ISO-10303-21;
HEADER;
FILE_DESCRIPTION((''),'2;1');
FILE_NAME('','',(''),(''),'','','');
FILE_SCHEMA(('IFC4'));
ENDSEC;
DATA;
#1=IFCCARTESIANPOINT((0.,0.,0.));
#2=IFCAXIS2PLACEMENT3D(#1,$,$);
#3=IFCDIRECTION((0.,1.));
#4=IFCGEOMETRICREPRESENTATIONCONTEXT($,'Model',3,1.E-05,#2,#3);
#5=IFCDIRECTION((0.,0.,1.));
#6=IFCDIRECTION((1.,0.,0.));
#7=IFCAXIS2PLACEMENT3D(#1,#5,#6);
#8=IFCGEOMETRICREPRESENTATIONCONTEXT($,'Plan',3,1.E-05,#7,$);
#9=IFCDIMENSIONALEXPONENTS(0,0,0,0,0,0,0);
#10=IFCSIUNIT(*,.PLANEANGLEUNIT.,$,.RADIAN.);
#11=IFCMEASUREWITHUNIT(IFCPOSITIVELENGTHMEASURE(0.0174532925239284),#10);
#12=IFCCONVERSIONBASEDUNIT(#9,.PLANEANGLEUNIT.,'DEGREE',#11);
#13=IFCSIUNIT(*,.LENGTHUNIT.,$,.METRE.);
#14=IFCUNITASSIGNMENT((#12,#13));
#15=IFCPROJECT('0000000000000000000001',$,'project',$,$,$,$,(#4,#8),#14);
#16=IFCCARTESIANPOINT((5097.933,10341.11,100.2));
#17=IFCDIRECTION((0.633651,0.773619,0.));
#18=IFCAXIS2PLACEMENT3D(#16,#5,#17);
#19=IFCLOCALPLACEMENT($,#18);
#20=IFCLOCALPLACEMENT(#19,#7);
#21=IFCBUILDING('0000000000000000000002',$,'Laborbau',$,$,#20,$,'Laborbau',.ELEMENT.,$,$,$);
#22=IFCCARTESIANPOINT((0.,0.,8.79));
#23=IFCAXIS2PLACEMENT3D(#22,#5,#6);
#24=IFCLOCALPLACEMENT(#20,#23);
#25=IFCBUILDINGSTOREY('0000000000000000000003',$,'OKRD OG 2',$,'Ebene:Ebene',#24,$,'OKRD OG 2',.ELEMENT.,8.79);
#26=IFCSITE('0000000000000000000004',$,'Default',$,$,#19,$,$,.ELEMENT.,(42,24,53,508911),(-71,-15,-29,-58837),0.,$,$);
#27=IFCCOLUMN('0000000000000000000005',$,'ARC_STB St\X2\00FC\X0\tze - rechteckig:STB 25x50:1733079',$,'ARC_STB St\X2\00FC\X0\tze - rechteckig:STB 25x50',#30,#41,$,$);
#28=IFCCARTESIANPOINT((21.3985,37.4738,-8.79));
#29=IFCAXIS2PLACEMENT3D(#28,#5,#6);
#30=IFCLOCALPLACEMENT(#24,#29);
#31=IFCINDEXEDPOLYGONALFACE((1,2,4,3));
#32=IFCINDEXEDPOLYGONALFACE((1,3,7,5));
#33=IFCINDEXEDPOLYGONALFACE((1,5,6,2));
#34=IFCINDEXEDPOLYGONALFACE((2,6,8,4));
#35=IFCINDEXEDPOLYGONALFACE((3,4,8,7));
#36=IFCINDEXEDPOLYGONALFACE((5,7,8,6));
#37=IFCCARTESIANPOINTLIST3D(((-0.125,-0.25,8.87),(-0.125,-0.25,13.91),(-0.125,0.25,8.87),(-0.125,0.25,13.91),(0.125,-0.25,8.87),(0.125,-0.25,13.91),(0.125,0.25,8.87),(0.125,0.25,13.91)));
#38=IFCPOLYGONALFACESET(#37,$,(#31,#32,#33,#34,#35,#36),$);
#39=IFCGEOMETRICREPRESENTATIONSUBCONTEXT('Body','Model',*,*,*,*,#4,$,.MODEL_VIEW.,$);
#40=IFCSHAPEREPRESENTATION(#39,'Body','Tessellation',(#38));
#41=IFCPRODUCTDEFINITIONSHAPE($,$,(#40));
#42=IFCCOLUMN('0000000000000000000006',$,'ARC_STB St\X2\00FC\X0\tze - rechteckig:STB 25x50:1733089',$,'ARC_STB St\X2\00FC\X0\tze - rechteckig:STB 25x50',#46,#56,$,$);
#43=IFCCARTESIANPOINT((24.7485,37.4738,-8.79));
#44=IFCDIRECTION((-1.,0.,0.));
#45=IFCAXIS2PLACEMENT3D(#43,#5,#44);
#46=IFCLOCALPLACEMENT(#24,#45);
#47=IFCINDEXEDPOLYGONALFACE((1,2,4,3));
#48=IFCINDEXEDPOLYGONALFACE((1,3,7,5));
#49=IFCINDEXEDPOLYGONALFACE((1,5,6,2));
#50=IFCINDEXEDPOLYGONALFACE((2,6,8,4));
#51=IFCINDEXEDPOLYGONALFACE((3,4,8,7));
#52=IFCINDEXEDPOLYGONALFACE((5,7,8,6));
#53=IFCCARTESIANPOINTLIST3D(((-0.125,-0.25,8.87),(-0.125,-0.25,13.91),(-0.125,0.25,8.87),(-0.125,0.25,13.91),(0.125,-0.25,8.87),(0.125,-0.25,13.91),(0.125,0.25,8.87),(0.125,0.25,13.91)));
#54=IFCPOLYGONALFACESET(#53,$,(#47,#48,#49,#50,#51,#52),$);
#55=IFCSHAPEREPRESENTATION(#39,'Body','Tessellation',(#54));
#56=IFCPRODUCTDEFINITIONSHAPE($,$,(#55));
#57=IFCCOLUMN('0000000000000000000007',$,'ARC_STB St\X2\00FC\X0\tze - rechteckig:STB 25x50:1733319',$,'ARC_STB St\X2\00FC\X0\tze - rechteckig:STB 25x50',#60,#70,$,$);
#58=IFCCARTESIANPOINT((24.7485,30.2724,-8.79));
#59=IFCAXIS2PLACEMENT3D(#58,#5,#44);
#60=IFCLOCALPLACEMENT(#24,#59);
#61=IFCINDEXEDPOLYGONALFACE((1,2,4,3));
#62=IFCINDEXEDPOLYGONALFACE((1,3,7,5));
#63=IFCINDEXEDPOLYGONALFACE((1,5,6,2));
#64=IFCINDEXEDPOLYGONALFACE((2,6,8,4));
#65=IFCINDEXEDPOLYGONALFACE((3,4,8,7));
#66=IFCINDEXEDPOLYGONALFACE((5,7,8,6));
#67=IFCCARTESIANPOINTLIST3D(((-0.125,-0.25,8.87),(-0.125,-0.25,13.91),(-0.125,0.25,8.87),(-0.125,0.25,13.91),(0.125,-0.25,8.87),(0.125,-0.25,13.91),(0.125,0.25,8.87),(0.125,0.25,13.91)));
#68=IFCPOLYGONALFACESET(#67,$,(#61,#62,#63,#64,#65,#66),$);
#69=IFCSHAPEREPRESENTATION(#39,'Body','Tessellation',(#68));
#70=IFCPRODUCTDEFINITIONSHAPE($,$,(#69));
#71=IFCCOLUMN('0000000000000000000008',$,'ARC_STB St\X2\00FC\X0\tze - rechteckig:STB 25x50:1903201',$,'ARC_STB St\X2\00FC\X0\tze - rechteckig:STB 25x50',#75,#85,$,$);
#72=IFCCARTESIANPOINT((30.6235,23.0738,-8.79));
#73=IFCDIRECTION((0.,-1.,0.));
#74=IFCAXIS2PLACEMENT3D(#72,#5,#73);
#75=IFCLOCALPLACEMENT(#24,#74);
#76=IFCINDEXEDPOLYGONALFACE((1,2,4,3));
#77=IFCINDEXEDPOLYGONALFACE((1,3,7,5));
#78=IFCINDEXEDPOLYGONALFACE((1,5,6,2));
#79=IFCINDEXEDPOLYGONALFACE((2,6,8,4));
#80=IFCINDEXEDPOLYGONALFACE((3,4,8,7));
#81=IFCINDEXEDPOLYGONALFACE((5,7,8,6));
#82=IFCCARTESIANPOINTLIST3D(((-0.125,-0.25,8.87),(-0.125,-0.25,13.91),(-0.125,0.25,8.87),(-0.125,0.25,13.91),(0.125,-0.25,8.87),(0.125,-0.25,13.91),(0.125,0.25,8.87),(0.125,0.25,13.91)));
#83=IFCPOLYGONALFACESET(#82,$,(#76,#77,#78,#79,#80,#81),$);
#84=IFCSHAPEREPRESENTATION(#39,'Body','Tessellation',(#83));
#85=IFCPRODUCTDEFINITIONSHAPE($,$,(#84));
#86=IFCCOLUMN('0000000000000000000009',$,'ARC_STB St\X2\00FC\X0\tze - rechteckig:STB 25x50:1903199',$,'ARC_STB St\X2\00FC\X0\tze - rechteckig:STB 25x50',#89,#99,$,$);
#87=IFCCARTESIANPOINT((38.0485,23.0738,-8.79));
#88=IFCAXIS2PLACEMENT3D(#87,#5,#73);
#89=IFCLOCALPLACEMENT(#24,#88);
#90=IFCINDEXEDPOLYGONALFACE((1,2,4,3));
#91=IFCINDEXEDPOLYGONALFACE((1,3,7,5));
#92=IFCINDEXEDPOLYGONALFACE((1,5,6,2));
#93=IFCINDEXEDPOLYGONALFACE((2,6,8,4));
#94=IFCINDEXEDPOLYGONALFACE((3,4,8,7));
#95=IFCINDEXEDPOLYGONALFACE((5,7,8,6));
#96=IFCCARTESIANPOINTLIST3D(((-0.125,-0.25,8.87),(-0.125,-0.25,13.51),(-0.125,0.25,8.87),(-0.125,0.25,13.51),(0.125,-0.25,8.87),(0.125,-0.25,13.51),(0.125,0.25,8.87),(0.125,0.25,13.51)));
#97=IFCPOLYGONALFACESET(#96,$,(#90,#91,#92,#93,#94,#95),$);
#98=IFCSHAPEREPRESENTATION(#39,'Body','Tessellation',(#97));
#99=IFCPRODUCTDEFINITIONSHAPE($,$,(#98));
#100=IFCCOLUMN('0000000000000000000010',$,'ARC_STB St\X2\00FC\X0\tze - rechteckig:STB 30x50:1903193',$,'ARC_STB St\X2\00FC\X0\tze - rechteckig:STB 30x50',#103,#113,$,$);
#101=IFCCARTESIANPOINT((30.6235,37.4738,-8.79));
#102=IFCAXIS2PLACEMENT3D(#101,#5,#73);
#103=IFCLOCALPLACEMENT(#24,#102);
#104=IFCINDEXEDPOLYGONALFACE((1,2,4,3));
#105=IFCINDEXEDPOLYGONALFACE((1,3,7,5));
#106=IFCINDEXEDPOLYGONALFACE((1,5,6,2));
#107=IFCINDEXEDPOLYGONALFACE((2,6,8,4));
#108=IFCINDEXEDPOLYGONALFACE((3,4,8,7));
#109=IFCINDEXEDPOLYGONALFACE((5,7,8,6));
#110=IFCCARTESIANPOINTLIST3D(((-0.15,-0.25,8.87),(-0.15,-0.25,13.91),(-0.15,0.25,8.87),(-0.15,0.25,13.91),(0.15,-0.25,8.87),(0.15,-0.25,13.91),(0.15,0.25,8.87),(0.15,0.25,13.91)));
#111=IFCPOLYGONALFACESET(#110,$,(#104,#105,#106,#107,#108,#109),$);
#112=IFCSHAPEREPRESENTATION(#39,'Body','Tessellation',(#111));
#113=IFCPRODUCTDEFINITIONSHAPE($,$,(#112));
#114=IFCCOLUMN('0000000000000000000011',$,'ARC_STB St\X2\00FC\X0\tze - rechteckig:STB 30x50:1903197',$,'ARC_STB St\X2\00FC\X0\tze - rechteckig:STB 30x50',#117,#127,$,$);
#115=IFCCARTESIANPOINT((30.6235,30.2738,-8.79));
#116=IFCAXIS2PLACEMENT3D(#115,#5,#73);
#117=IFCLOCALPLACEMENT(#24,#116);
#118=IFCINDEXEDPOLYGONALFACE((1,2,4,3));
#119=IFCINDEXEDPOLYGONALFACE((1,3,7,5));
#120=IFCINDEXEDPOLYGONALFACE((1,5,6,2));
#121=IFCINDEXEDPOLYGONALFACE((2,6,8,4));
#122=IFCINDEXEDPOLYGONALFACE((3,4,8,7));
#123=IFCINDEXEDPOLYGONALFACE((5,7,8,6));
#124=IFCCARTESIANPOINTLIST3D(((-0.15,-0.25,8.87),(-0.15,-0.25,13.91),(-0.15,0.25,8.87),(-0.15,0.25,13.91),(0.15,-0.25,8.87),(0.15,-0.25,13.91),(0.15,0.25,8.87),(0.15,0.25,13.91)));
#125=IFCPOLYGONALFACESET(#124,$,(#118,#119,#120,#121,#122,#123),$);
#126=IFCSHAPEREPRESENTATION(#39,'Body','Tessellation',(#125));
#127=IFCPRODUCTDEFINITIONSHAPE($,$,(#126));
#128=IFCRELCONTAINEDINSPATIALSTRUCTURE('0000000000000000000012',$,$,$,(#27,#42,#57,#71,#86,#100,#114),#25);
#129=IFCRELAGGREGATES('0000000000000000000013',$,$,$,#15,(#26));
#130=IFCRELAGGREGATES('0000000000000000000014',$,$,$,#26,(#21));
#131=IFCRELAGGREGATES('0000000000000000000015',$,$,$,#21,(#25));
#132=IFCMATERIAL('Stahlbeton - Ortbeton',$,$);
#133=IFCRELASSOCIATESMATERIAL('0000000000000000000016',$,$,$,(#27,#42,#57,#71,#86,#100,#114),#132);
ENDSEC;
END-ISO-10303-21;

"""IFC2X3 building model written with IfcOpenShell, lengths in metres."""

from ifc_helpers import new_model, entity, si_unit, converted_unit, direction, frame, origin, origin_with_axes, origin_2d_with_axis, place, context, subcontext, project, spatial, rectangle, extrude, source, transform, mapped, material, element, save


model = new_model("IFC2X3")

# Units and contexts
model_context = context("Model", 3, precision=1e-05, world=origin(), true_north=direction((0.0, 1.0)))
plan_context = context("Plan", 3, precision=1e-05, world=origin_with_axes())
body_context = subcontext(model_context, "Body", "Model", "MODEL_VIEW")
ifc_project = project(units=[converted_unit("PLANEANGLEUNIT", "DEGREE", entity("IfcPositiveLengthMeasure", 0.0174532925239284), si_unit("PLANEANGLEUNIT", "RADIAN"), dimensions=[0, 0, 0, 0, 0, 0, 0]), si_unit("LENGTHUNIT", "METRE")], contexts=[model_context, plan_context])

# Site, building, storey
site_placement = place(None, frame((5097.933, 10341.11, 100.2), z_axis=(0.0, 0.0, 1.0), x_axis=(0.633651, 0.773619, 0.0)))
site = spatial("IfcSite", under=ifc_project, at=site_placement, Name="Default", CompositionType="ELEMENT", RefLatitude=(42, 24, 53, 508911), RefLongitude=(-71, -15, -29, -58837), RefElevation=0.0)
building_placement = place(site_placement, origin_with_axes())
building = spatial("IfcBuilding", under=site, at=building_placement, Name="Laborbau", LongName="Laborbau", CompositionType="ELEMENT")
storey_placement = place(building_placement, frame((0.0, 0.0, 8.79), z_axis=(0.0, 0.0, 1.0), x_axis=(1.0, 0.0, 0.0)))
storey = spatial("IfcBuildingStorey", under=building, at=storey_placement, Name="OKRD OG 2", ObjectType="Ebene:Ebene", LongName="OKRD OG 2", CompositionType="ELEMENT", Elevation=8.79)

# Columns
ifc_material_1 = material(Name="Stahlbeton - Ortbeton")
shared_shape_1 = source(origin(), body_context, "Body", "SweptSolid", [
    extrude(rectangle(XDim=0.5, YDim=0.25, at=origin_2d_with_axis()), frame((0.0, 0.0, 8.87), z_axis=(0.0, 0.0, 1.0), x_axis=(0.0, -1.0, 0.0)), (0.0, 0.0, 1.0), 5.04),
])
for number, where, z_axis, x_axis, name in (
    (1, (21.3985, 37.4738, -8.79), (0.0, 0.0, 1.0), (1.0, 0.0, 0.0), "ARC_STB Stütze - rechteckig:STB 25x50:1733079"),
    (2, (24.7485, 37.4738, -8.79), (0.0, 0.0, 1.0), (-1.0, 0.0, 0.0), "ARC_STB Stütze - rechteckig:STB 25x50:1733089"),
    (3, (24.7485, 30.2724, -8.79), (0.0, 0.0, 1.0), (-1.0, 0.0, 0.0), "ARC_STB Stütze - rechteckig:STB 25x50:1733319"),
    (4, (30.6235, 23.0738, -8.79), (0.0, 0.0, 1.0), (0.0, -1.0, 0.0), "ARC_STB Stütze - rechteckig:STB 25x50:1903201"),
):
    element("IfcColumn", number, at=place(storey_placement, frame(where, z_axis=z_axis, x_axis=x_axis)), inside=storey, material=ifc_material_1, Name=name, ObjectType="ARC_STB Stütze - rechteckig:STB 25x50", context=body_context, shape_type="MappedRepresentation", body=[
        mapped(shared_shape_1, transform((0.0, 0.0, 0.0), scale=1.0)),
    ])
shared_shape_2 = source(origin(), body_context, "Body", "SweptSolid", [
    extrude(rectangle(XDim=0.5, YDim=0.25, at=origin_2d_with_axis()), frame((0.0, 0.0, 8.87), z_axis=(0.0, 0.0, 1.0), x_axis=(0.0, -1.0, 0.0)), (0.0, 0.0, 1.0), 4.64),
])
column_placement = place(storey_placement, frame((38.0485, 23.0738, -8.79), z_axis=(0.0, 0.0, 1.0), x_axis=(0.0, -1.0, 0.0)))
element("IfcColumn", 5, at=column_placement, inside=storey, material=ifc_material_1, Name="ARC_STB Stütze - rechteckig:STB 25x50:1903199", ObjectType="ARC_STB Stütze - rechteckig:STB 25x50", context=body_context, shape_type="MappedRepresentation", body=[
    mapped(shared_shape_2, transform((0.0, 0.0, 0.0), scale=1.0)),
])
shared_shape_3 = source(origin(), body_context, "Body", "SweptSolid", [
    extrude(rectangle(XDim=0.5, YDim=0.3, at=origin_2d_with_axis()), frame((0.0, 0.0, 8.87), z_axis=(0.0, 0.0, 1.0), x_axis=(0.0, -1.0, 0.0)), (0.0, 0.0, 1.0), 5.04),
])
for number, where, z_axis, x_axis, name in (
    (6, (30.6235, 37.4738, -8.79), (0.0, 0.0, 1.0), (0.0, -1.0, 0.0), "ARC_STB Stütze - rechteckig:STB 30x50:1903193"),
    (7, (30.6235, 30.2738, -8.79), (0.0, 0.0, 1.0), (0.0, -1.0, 0.0), "ARC_STB Stütze - rechteckig:STB 30x50:1903197"),
):
    element("IfcColumn", number, at=place(storey_placement, frame(where, z_axis=z_axis, x_axis=x_axis)), inside=storey, material=ifc_material_1, Name=name, ObjectType="ARC_STB Stütze - rechteckig:STB 30x50", context=body_context, shape_type="MappedRepresentation", body=[
        mapped(shared_shape_3, transform((0.0, 0.0, 0.0), scale=1.0)),
    ])

save(model, "model.ifc")
